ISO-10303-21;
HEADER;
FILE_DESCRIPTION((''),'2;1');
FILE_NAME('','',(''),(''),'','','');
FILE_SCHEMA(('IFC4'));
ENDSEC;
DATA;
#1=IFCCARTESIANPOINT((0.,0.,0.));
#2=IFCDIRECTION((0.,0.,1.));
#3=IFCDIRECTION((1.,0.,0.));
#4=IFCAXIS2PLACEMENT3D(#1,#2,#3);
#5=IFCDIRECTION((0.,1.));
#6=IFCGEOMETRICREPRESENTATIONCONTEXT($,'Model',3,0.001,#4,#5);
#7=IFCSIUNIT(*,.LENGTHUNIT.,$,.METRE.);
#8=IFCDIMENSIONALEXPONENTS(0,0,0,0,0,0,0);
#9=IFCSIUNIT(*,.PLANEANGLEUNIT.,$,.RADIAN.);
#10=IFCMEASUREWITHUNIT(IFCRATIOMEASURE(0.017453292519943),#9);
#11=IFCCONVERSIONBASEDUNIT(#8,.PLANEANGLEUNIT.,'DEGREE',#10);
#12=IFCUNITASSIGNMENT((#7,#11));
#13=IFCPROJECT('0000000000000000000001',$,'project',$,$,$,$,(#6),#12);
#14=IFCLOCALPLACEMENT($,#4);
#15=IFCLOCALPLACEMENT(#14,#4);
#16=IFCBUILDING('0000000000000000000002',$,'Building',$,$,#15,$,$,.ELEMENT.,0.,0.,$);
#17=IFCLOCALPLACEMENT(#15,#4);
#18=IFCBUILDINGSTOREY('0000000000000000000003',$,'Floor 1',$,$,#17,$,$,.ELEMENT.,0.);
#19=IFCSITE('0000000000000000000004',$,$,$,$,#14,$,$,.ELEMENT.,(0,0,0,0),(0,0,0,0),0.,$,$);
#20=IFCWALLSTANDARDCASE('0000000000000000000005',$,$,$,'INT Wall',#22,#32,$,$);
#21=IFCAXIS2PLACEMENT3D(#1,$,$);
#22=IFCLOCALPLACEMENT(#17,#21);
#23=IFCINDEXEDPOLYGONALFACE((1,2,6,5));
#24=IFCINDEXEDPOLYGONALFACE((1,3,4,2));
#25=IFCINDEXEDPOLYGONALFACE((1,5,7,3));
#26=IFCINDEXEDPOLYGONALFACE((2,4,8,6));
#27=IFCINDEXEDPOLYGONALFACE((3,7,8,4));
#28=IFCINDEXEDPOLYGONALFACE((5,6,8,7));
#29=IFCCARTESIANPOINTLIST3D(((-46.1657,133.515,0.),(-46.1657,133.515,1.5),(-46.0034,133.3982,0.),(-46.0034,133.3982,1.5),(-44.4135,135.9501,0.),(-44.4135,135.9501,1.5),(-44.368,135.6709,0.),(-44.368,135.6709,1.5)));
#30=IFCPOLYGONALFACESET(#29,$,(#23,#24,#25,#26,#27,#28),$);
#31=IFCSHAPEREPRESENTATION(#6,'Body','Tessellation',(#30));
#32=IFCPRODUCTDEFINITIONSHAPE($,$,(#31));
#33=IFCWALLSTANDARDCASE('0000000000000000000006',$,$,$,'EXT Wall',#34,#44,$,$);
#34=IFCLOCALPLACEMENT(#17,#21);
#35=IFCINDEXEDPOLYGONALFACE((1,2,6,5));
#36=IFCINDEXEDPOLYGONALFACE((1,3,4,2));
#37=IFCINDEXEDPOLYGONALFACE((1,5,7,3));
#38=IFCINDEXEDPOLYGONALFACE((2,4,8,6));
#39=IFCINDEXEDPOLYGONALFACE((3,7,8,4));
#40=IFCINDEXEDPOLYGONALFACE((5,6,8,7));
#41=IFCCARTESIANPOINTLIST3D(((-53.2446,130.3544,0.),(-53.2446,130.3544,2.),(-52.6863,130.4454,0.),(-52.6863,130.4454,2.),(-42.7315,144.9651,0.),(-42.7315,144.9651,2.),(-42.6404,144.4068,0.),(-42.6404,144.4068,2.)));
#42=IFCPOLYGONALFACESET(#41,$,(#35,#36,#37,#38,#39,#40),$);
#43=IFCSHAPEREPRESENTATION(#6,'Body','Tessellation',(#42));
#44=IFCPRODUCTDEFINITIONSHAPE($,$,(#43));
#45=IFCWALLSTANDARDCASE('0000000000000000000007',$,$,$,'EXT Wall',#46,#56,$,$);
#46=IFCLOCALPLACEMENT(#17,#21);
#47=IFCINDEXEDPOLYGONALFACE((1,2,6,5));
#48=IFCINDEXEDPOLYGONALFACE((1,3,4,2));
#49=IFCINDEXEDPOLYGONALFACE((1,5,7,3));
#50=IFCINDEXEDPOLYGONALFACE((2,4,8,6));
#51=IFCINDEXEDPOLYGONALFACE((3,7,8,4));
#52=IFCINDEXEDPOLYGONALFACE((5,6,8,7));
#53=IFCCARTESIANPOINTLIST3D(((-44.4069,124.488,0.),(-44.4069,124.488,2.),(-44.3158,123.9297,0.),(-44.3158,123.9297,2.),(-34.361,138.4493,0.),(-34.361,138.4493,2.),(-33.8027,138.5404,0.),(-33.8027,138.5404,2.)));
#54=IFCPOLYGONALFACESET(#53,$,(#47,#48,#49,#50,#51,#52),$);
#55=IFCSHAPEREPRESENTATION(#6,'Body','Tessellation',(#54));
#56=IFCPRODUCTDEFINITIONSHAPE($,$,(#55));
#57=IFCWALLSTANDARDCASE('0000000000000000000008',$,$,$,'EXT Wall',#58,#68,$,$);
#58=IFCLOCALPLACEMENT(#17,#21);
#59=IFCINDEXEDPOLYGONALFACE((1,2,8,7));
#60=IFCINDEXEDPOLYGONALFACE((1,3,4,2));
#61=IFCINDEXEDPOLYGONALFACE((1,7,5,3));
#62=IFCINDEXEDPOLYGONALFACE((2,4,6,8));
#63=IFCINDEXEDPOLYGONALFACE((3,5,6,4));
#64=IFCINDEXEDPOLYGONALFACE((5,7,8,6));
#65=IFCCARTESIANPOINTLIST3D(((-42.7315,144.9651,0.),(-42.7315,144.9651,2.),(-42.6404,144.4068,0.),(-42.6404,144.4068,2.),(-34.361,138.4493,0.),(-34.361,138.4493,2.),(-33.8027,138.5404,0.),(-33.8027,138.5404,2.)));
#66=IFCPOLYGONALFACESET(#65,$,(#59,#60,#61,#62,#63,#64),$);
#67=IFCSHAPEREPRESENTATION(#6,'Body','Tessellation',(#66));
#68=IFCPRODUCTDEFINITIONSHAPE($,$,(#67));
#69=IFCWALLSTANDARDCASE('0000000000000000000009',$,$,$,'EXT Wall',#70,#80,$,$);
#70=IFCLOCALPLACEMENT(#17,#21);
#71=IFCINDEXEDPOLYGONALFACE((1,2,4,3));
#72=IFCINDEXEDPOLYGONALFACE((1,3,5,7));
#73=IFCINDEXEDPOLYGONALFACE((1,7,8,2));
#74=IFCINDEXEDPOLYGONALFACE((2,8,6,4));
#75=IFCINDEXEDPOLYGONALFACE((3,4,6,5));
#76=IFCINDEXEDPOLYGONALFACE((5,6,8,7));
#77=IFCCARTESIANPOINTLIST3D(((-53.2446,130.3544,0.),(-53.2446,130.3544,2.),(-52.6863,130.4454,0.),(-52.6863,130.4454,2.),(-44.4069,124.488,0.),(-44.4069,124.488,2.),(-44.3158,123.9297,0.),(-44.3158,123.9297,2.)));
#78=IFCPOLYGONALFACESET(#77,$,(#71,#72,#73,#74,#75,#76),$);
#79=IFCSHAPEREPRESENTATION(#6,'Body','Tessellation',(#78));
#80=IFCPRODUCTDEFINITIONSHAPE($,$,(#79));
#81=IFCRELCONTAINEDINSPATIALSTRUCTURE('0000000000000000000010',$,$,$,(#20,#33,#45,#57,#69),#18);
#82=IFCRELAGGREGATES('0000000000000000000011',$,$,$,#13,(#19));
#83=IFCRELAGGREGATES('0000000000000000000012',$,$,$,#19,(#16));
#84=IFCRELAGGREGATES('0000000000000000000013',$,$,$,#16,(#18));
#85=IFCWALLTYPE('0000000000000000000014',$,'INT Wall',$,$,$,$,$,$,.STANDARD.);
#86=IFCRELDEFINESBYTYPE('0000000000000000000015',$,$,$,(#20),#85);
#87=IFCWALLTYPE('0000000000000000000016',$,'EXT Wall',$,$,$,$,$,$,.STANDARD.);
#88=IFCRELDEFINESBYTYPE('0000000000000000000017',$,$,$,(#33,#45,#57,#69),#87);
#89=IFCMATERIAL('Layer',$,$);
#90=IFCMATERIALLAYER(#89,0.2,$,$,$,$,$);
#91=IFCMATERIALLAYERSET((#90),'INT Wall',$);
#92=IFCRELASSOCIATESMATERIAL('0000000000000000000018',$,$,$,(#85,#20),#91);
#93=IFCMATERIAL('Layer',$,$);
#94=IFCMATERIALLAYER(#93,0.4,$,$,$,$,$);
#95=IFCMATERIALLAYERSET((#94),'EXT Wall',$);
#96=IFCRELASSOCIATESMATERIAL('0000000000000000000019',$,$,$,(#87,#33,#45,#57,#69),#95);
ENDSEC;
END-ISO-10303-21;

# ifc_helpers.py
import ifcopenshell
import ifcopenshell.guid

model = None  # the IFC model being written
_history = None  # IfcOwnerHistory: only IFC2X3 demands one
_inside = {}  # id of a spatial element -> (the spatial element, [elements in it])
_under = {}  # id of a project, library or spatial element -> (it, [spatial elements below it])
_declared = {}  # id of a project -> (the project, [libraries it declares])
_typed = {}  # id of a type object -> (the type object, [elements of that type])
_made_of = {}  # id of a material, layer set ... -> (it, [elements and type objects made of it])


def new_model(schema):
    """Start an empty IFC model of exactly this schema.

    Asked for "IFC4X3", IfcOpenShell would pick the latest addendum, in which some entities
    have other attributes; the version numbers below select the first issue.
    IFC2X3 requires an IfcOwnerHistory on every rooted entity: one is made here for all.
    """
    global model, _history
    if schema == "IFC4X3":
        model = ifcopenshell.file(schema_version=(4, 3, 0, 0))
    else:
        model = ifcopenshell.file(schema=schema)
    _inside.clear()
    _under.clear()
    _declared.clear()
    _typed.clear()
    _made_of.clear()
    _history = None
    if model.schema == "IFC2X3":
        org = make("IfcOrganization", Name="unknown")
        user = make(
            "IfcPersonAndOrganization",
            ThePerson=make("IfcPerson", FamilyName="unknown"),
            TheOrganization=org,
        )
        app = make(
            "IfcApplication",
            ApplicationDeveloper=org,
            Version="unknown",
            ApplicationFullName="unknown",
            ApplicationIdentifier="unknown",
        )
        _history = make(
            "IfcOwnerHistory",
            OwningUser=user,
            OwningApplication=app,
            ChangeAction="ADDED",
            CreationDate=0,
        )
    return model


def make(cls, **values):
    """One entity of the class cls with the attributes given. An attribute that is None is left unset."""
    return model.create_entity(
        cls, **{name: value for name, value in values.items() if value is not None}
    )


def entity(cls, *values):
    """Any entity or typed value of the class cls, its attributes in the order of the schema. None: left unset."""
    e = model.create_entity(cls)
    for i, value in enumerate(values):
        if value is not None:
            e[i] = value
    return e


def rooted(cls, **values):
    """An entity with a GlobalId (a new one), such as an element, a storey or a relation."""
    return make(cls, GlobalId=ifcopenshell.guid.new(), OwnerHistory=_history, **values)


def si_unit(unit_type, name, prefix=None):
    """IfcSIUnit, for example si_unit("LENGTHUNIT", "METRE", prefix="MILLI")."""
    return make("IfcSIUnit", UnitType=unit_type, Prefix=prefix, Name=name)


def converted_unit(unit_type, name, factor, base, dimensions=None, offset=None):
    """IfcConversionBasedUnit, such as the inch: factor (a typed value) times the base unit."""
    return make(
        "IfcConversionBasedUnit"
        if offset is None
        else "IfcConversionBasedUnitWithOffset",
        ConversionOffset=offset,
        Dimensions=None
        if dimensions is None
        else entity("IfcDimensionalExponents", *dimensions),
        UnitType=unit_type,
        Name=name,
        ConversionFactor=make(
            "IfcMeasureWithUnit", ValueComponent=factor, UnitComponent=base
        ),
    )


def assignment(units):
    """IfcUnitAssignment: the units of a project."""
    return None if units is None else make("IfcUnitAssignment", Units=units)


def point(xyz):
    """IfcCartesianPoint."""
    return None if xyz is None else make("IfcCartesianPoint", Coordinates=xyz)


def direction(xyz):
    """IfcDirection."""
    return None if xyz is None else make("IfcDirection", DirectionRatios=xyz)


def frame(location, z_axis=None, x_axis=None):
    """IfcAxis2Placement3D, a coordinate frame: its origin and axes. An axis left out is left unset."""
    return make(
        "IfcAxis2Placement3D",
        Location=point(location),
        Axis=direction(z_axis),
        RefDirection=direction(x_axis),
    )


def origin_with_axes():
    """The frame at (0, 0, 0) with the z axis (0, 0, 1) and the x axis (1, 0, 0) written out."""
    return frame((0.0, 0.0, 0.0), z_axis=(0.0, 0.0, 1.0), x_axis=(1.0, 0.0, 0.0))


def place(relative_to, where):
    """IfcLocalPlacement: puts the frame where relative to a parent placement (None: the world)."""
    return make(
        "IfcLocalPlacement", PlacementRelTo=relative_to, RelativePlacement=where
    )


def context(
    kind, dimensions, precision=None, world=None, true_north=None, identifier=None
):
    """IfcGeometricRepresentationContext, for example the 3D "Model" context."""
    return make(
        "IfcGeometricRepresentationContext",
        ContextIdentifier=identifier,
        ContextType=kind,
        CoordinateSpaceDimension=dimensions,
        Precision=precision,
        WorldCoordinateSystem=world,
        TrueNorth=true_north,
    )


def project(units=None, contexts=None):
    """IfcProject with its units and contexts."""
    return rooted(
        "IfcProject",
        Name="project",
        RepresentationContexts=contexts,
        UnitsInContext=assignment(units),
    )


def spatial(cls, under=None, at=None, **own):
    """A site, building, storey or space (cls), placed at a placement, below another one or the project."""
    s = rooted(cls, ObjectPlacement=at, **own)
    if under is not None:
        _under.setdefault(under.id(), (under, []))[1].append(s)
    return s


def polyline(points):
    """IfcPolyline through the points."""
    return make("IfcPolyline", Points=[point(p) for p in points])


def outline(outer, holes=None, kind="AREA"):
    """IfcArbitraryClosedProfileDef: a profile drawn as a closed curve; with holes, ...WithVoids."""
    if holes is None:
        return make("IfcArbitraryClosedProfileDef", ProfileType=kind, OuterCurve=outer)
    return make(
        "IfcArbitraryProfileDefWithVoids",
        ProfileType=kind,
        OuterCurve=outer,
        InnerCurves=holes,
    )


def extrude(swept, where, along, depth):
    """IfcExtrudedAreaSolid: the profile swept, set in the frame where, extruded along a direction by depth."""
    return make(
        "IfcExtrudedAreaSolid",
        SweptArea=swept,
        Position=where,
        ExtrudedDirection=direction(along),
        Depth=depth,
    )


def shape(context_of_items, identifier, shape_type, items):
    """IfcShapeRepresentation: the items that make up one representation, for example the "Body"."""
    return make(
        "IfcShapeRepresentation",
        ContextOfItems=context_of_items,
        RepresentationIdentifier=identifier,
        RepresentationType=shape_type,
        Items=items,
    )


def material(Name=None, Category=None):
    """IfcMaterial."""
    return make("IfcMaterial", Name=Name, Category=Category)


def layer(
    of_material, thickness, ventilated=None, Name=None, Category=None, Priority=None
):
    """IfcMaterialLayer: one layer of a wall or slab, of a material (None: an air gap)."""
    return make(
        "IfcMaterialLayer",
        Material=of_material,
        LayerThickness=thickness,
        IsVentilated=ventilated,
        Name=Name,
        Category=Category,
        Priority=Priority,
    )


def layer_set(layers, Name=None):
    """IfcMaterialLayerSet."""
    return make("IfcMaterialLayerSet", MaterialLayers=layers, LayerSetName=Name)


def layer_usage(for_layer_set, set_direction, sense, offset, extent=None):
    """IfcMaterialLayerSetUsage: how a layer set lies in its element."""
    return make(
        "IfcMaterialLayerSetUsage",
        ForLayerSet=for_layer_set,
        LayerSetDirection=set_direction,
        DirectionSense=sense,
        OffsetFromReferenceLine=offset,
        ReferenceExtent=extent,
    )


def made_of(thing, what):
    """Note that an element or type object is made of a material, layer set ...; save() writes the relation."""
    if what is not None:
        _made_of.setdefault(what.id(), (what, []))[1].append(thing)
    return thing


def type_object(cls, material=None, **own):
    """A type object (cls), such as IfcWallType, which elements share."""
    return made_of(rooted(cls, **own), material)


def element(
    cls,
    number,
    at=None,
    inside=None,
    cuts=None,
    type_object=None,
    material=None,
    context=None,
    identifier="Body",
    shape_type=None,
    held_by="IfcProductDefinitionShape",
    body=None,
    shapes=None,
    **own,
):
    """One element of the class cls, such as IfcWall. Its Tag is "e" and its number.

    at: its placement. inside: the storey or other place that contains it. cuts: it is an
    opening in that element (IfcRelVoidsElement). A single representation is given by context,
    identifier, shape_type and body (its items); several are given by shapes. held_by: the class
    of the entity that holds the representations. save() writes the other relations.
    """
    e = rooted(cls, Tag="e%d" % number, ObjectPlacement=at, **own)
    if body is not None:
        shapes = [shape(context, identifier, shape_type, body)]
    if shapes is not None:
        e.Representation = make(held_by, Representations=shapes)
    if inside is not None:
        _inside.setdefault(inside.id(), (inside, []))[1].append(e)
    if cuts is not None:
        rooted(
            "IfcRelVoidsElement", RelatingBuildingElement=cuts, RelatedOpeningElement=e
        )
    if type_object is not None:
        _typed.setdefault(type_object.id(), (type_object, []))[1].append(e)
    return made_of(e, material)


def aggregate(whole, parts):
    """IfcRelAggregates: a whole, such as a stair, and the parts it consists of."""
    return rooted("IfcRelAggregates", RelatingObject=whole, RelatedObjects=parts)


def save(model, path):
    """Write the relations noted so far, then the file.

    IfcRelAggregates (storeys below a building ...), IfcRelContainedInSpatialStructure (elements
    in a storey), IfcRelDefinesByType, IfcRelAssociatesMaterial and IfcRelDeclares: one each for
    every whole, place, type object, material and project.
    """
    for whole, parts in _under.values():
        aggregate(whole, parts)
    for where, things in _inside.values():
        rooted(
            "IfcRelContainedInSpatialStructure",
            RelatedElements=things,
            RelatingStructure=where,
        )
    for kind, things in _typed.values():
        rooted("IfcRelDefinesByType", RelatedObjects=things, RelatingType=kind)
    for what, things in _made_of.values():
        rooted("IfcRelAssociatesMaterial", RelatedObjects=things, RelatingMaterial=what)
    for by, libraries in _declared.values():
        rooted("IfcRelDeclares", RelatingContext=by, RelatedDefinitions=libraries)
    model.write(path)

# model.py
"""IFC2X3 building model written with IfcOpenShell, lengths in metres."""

from ifc_helpers import new_model, entity, si_unit, converted_unit, direction, frame, origin_with_axes, place, context, project, spatial, polyline, outline, extrude, material, layer, layer_set, layer_usage, type_object, element, save


model = new_model("IFC2X3")

# Units and contexts
model_context = context("Model", 3, precision=0.001, world=origin_with_axes(), true_north=direction((0.0, 1.0)))
ifc_project = project(units=[si_unit("LENGTHUNIT", "METRE"), converted_unit("PLANEANGLEUNIT", "DEGREE", entity("IfcRatioMeasure", 0.017453292519943), si_unit("PLANEANGLEUNIT", "RADIAN"), dimensions=[0, 0, 0, 0, 0, 0, 0])], contexts=[model_context])

# Site, building, storey
site_placement = place(None, origin_with_axes())
site = spatial("IfcSite", under=ifc_project, at=site_placement, CompositionType="ELEMENT", RefLatitude=(0, 0, 0, 0), RefLongitude=(0, 0, 0, 0), RefElevation=0.0)
building_placement = place(site_placement, origin_with_axes())
building = spatial("IfcBuilding", under=site, at=building_placement, Name="Building", CompositionType="ELEMENT", ElevationOfRefHeight=0.0, ElevationOfTerrain=0.0)
storey_placement = place(building_placement, origin_with_axes())
storey = spatial("IfcBuildingStorey", under=building, at=storey_placement, Name="Floor 1", CompositionType="ELEMENT", Elevation=0.0)

# Walls
ifc_material_1 = material(Name="Layer")
ifc_layer_1 = layer(ifc_material_1, 0.2)
ifc_layer_set_1 = layer_set([ifc_layer_1], Name="INT Wall")
ifc_layer_usage_1 = layer_usage(ifc_layer_set_1, "AXIS2", "POSITIVE", -0.1)
wall_type_1 = type_object("IfcWallType", Name="INT Wall", PredefinedType="STANDARD", material=ifc_layer_set_1)
wall_1_placement = place(site_placement, frame((-44.3908, 135.8105, 0.0), z_axis=(0.0, 0.0, 1.0), x_axis=(-0.584065, -0.811707, 0.0)))
element("IfcWallStandardCase", 1, at=wall_1_placement, inside=storey, type_object=wall_type_1, material=ifc_layer_usage_1, ObjectType="INT Wall", context=model_context, shape_type="SweptSolid", body=[
    extrude(outline(polyline([(2.9, 0.1), (2.9, -0.1), (-0.1, -0.1), (0.1, 0.1), (2.9, 0.1)])), origin_with_axes(), (0.0, 0.0, 1.0), 1.5),
])
ifc_material_2 = material(Name="Layer")
ifc_layer_2 = layer(ifc_material_2, 0.4)
ifc_layer_set_2 = layer_set([ifc_layer_2], Name="EXT Wall")
ifc_layer_usage_2 = layer_usage(ifc_layer_set_2, "AXIS2", "POSITIVE", -0.2)
wall_type_2 = type_object("IfcWallType", Name="EXT Wall", PredefinedType="STANDARD", material=ifc_layer_set_2)
wall_2_placement = place(site_placement, frame((-42.7315, 144.9651, 0.0), z_axis=(0.0, 0.0, 1.0), x_axis=(-0.584065, -0.811707, 0.0)))
element("IfcWallStandardCase", 2, at=wall_2_placement, inside=storey, type_object=wall_type_2, material=ifc_layer_usage_2, ObjectType="EXT Wall", context=model_context, shape_type="SweptSolid", body=[
    extrude(outline(polyline([(18.0, 0.0), (17.6, 0.4), (0.4, 0.4), (0.0, 0.0), (18.0, 0.0)])), origin_with_axes(), (0.0, 0.0, 1.0), 2.0),
])
wall_3_placement = place(site_placement, frame((-44.3158, 123.9297, 0.0), z_axis=(0.0, 0.0, 1.0), x_axis=(0.584065, 0.811707, 0.0)))
element("IfcWallStandardCase", 3, at=wall_3_placement, inside=storey, type_object=wall_type_2, material=ifc_layer_usage_2, ObjectType="EXT Wall", context=model_context, shape_type="SweptSolid", body=[
    extrude(outline(polyline([(18.0, 0.0), (17.6, 0.4), (0.4, 0.4), (0.0, 0.0), (18.0, 0.0)])), origin_with_axes(), (0.0, 0.0, 1.0), 2.0),
])
wall_4_placement = place(site_placement, frame((-33.8027, 138.5404, 0.0), z_axis=(0.0, 0.0, 1.0), x_axis=(-0.811707, 0.584065, 0.0)))
element("IfcWallStandardCase", 4, at=wall_4_placement, inside=storey, type_object=wall_type_2, material=ifc_layer_usage_2, ObjectType="EXT Wall", context=model_context, shape_type="SweptSolid", body=[
    extrude(outline(polyline([(11.0, 0.0), (10.6, 0.4), (0.4, 0.4), (0.0, 0.0), (11.0, 0.0)])), origin_with_axes(), (0.0, 0.0, 1.0), 2.0),
])
wall_5_placement = place(site_placement, frame((-53.2446, 130.3544, 0.0), z_axis=(0.0, 0.0, 1.0), x_axis=(0.811707, -0.584065, 0.0)))
element("IfcWallStandardCase", 5, at=wall_5_placement, inside=storey, type_object=wall_type_2, material=ifc_layer_usage_2, ObjectType="EXT Wall", context=model_context, shape_type="SweptSolid", body=[
    extrude(outline(polyline([(11.0, 0.0), (10.6, 0.4), (0.4, 0.4), (0.0, 0.0), (11.0, 0.0)])), origin_with_axes(), (0.0, 0.0, 1.0), 2.0),
])

save(model, "model.ifc")
